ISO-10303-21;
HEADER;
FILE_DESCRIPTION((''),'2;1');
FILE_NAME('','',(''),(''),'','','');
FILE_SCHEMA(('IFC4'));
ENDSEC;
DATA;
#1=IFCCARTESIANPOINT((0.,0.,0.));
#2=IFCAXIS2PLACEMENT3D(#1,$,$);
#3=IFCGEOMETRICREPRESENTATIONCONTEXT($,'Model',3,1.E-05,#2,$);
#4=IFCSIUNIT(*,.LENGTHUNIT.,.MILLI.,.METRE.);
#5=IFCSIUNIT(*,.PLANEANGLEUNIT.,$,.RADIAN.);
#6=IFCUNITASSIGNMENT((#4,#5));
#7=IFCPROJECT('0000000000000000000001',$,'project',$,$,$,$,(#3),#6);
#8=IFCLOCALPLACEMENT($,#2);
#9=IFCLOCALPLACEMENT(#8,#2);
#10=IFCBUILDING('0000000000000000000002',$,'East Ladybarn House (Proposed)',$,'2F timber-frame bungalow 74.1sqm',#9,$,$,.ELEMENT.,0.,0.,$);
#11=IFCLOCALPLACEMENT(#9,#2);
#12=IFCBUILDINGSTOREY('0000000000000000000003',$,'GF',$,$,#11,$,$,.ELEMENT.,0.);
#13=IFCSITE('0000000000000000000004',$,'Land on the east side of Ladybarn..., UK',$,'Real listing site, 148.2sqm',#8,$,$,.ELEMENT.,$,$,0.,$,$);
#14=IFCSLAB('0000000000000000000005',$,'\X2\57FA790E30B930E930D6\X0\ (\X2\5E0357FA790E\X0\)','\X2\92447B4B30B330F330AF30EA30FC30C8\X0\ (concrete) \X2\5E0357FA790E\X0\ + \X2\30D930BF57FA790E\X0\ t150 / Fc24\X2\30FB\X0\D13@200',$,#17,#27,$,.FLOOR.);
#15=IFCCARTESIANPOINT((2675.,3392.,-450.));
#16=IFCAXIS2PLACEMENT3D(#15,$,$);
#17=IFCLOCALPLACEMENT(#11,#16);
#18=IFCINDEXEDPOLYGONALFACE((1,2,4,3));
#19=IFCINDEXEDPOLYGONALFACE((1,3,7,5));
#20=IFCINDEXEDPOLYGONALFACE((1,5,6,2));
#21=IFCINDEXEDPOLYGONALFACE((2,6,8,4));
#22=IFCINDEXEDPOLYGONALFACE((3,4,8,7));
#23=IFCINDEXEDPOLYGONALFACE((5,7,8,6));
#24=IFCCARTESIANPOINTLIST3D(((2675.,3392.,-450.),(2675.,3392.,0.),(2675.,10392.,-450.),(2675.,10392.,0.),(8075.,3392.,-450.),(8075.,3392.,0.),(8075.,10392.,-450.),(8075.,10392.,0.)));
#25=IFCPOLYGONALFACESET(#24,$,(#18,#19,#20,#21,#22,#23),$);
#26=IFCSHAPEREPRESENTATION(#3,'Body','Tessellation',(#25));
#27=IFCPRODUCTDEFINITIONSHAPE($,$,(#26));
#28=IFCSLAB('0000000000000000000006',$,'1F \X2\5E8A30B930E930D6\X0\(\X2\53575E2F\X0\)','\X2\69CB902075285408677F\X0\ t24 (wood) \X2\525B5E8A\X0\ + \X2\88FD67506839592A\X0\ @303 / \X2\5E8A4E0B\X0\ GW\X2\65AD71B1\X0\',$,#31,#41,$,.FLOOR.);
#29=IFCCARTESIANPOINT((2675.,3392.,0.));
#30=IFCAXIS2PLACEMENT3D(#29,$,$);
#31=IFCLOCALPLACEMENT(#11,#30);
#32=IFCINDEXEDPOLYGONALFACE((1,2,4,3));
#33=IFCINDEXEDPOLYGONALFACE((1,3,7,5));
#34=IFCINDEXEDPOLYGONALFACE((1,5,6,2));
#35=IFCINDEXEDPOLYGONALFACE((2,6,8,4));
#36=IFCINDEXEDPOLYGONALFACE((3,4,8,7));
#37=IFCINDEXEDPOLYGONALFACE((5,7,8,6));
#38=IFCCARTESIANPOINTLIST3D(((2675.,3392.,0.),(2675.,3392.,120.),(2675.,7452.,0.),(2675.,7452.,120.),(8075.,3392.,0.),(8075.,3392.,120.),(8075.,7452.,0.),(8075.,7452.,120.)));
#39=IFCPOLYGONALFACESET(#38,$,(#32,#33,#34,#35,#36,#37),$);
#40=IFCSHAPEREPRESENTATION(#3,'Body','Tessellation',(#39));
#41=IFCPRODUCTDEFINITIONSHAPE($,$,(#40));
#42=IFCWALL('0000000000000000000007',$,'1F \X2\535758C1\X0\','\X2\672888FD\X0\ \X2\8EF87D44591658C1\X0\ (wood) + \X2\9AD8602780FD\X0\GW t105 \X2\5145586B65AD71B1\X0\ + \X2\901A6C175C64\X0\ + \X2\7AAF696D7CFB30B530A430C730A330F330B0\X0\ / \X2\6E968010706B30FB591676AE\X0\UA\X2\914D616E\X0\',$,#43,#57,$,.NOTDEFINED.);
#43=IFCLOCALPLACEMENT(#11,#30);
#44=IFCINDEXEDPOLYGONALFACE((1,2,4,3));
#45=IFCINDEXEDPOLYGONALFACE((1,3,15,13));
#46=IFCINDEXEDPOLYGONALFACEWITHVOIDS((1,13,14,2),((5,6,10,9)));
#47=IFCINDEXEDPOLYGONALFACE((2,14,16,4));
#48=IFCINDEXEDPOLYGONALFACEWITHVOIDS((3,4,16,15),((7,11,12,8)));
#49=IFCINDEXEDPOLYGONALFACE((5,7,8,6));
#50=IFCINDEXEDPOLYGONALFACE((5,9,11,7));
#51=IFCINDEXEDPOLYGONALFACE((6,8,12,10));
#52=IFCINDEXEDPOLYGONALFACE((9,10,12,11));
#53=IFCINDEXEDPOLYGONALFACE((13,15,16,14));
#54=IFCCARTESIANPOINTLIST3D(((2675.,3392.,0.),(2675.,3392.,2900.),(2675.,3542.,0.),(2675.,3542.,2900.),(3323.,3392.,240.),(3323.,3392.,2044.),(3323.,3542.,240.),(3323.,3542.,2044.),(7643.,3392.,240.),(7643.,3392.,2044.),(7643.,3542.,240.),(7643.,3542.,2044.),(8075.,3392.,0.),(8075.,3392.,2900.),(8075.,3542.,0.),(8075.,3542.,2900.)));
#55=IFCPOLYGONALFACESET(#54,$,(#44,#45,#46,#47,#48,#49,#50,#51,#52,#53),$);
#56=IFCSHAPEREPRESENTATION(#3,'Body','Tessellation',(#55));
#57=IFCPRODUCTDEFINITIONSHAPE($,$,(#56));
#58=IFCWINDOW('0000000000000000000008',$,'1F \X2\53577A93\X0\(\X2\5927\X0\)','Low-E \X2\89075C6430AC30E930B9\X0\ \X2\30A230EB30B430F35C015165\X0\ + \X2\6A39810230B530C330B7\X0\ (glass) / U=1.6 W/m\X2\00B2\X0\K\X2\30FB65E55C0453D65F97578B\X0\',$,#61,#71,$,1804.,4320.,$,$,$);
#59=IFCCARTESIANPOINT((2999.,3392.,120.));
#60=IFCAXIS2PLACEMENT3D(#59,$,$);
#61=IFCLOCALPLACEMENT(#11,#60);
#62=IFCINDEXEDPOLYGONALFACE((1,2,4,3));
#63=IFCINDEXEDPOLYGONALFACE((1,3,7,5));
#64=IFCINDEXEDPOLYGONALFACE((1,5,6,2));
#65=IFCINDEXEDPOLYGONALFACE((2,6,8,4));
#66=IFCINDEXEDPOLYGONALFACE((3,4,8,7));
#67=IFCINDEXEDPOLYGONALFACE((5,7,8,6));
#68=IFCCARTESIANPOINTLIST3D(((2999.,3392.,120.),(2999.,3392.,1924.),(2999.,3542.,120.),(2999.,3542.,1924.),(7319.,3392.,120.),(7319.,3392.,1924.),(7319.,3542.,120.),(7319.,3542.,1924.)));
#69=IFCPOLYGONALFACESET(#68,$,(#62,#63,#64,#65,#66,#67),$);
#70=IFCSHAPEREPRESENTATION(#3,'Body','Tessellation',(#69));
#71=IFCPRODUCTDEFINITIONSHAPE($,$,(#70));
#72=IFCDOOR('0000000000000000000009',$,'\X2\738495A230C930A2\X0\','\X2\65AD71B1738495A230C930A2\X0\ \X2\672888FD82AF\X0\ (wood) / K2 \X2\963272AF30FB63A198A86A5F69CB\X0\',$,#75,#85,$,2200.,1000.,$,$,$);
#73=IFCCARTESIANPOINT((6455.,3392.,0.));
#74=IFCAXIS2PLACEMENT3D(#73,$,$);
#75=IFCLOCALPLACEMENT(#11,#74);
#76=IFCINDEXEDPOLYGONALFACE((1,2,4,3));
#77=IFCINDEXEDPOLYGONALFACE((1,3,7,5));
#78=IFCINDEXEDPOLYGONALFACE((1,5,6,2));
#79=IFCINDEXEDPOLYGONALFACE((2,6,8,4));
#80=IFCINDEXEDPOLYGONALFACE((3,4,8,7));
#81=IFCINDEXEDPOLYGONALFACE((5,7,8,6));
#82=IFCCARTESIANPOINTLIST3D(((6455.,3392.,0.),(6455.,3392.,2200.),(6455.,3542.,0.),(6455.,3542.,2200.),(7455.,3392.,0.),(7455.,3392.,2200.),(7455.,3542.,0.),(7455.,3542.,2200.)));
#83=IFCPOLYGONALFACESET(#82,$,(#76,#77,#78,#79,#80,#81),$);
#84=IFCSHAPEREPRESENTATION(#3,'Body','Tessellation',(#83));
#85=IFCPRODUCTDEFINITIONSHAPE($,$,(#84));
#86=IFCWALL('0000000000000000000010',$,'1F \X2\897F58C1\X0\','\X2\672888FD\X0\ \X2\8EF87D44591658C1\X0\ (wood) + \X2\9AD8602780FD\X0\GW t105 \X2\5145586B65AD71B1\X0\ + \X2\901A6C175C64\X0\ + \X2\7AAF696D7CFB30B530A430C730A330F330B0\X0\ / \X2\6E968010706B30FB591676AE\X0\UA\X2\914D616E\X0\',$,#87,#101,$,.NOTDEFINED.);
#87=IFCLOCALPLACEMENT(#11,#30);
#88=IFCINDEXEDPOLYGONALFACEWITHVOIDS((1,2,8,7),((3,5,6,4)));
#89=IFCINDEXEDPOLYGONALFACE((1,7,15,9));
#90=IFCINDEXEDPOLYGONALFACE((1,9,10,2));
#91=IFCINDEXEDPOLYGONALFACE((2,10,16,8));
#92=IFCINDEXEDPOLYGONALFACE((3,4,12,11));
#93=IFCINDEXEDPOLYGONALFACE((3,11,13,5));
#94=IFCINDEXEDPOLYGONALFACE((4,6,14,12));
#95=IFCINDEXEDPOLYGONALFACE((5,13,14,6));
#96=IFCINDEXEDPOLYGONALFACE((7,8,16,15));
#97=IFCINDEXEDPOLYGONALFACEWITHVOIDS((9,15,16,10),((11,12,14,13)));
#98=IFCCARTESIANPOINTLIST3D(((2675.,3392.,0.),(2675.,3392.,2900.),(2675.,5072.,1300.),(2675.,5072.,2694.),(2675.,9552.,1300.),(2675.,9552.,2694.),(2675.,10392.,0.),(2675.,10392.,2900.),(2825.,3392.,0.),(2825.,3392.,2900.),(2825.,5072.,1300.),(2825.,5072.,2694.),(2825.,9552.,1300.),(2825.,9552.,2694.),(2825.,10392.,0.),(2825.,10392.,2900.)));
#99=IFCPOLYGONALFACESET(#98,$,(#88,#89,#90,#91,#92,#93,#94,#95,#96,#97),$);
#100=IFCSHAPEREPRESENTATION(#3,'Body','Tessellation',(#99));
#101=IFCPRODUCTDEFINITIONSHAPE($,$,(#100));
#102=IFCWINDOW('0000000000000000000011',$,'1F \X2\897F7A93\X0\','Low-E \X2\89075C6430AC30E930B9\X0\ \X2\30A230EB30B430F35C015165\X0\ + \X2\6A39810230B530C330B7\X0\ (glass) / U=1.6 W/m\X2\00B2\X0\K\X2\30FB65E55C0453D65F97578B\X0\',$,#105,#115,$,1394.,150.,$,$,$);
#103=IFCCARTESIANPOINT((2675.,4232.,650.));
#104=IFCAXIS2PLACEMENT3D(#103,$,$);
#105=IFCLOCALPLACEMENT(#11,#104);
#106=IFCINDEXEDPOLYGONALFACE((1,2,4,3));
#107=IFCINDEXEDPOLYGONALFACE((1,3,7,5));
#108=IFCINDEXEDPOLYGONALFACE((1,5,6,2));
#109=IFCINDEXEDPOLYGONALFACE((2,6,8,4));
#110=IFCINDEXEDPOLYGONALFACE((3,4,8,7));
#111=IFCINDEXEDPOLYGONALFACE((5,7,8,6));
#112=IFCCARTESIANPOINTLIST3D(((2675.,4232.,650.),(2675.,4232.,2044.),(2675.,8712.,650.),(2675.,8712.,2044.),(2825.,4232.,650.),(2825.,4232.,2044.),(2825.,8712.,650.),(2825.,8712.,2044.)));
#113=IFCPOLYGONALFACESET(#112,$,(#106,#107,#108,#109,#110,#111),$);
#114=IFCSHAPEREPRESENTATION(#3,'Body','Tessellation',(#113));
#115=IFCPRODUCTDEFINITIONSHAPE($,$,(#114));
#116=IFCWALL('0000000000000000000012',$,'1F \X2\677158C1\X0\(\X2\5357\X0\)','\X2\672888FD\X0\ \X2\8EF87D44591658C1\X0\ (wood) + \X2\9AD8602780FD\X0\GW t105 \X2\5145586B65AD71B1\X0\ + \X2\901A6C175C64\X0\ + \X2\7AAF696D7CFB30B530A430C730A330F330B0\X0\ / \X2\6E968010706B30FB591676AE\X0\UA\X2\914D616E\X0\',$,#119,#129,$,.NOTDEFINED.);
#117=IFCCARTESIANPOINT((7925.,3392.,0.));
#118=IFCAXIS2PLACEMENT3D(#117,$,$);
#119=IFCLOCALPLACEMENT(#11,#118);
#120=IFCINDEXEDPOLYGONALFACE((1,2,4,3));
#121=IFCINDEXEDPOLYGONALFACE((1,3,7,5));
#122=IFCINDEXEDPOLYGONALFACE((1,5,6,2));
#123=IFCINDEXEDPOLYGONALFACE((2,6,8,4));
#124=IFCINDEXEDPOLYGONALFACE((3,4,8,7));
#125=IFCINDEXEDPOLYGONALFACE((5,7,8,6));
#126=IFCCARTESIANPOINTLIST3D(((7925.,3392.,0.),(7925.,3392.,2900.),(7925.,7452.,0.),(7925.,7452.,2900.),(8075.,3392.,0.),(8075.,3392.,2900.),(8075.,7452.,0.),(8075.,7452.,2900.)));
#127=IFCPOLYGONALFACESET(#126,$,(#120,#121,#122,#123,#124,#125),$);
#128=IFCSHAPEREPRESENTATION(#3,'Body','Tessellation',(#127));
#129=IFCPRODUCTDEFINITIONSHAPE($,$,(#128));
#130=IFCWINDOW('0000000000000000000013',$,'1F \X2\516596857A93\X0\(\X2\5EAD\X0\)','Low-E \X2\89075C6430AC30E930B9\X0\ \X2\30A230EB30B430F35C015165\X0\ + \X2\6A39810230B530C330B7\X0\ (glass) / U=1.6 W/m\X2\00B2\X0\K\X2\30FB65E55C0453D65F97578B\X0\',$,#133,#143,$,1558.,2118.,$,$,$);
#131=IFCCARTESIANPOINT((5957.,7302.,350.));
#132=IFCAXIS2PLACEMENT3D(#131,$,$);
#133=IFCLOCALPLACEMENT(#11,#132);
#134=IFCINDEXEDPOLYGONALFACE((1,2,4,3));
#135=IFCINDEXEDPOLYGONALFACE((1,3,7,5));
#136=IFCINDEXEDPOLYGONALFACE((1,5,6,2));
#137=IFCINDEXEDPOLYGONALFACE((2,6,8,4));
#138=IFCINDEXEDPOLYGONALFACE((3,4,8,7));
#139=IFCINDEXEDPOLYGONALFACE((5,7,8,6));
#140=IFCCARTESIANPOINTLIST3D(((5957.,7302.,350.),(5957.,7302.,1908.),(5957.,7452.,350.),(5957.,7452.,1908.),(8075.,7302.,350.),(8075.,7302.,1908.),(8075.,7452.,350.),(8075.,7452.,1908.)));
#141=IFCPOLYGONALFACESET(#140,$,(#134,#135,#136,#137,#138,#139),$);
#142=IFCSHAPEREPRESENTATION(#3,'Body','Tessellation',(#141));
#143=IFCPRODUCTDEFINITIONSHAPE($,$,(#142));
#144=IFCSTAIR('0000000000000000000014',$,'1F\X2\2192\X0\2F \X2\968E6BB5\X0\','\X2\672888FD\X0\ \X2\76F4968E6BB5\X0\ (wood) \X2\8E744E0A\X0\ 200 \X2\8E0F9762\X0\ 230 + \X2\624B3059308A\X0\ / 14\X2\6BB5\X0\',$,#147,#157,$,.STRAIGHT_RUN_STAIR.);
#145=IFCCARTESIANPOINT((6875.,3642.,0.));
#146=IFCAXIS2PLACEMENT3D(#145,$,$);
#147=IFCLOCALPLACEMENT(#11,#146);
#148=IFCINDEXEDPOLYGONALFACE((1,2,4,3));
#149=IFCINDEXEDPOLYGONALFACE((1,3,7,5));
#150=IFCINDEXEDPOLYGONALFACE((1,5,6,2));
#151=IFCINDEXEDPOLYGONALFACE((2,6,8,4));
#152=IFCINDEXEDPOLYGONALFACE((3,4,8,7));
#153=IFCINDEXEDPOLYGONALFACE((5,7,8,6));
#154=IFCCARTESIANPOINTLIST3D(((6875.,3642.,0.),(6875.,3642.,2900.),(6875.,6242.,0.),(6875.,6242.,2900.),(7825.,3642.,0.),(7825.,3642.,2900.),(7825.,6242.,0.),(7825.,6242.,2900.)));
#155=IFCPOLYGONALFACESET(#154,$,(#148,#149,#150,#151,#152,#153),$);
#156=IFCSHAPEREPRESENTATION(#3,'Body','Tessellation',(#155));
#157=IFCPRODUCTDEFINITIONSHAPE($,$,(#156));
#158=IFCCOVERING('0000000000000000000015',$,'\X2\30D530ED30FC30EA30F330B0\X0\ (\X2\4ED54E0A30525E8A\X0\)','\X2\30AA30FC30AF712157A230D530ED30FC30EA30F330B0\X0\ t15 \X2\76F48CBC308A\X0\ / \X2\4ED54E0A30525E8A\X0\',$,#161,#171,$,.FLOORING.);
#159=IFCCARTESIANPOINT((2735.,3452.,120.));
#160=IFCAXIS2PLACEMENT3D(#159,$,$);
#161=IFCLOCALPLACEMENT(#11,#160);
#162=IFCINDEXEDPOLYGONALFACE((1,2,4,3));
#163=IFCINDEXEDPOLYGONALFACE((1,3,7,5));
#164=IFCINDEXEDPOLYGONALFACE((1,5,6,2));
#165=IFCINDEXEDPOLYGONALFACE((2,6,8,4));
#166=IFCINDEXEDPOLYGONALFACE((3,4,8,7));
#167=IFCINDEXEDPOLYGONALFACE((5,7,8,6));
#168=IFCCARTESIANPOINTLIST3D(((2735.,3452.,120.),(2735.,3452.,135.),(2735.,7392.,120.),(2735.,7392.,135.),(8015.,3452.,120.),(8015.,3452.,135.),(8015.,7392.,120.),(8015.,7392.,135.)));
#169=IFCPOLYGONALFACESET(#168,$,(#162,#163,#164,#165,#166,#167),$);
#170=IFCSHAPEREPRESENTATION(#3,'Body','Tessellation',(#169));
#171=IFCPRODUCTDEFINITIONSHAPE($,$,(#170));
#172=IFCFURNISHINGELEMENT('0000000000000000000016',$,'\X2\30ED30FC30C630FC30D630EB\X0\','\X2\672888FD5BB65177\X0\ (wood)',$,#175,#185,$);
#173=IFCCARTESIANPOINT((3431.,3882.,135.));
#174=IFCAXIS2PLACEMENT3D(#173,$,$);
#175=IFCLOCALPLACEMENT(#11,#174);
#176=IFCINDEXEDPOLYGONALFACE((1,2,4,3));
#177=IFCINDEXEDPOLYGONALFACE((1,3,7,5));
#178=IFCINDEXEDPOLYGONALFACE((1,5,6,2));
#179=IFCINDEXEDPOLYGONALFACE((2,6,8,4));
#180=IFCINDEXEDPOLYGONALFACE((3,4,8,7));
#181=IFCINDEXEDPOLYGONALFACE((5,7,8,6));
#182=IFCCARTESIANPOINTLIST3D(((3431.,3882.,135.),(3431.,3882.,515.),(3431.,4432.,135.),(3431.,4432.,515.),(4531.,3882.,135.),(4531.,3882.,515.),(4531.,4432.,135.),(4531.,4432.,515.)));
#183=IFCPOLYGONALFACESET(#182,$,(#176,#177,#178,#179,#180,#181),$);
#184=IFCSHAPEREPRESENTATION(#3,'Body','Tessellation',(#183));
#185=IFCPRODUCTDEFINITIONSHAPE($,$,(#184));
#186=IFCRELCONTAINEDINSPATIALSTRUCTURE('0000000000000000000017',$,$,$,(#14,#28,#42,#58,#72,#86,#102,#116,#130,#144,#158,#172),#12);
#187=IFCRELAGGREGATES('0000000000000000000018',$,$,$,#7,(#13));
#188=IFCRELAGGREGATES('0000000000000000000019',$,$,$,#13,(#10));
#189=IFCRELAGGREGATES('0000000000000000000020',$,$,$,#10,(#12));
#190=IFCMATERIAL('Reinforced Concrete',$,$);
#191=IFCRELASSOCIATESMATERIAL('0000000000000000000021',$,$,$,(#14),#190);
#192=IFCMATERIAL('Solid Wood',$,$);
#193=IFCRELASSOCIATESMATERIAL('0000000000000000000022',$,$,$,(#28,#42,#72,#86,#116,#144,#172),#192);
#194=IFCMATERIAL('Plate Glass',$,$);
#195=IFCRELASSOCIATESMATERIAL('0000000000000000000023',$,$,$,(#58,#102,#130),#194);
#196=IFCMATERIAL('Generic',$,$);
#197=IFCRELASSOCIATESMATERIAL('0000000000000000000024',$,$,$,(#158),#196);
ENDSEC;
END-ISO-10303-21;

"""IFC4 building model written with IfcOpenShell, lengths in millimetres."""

from ifc_helpers import new_model, si_unit, frame, frame_2d, origin, place, context, project, spatial, rectangle, extrude, material, element, fill, save


model = new_model("IFC4")

# Units and contexts
model_context = context("Model", 3, precision=1e-05, world=origin())
ifc_project = project(units=[si_unit("LENGTHUNIT", "METRE", prefix="MILLI"), si_unit("PLANEANGLEUNIT", "RADIAN")], contexts=[model_context])

# Site, building, storey
site_placement = place(None, origin())
site = spatial("IfcSite", under=ifc_project, at=site_placement, Name="Land on the east side of Ladybarn..., UK", ObjectType="Real listing site, 148.2sqm", CompositionType="ELEMENT", RefElevation=0.0)
building_placement = place(site_placement, origin())
building = spatial("IfcBuilding", under=site, at=building_placement, Name="East Ladybarn House (Proposed)", ObjectType="2F timber-frame bungalow 74.1sqm", CompositionType="ELEMENT", ElevationOfRefHeight=0.0, ElevationOfTerrain=0.0)
storey_placement = place(building_placement, origin())
storey = spatial("IfcBuildingStorey", under=building, at=storey_placement, Name="GF", CompositionType="ELEMENT", Elevation=0.0)

# Slabs
ifc_material_1 = material(Name="Reinforced Concrete")
slab_1_placement = place(storey_placement, frame((2675.0, 3392.0, -450.0)))
element("IfcSlab", 1, at=slab_1_placement, inside=storey, material=ifc_material_1, Name="基礎スラブ (布基礎)", Description="鉄筋コンクリート (concrete) 布基礎 + ベタ基礎 t150 / Fc24・D13@200", PredefinedType="FLOOR", context=model_context, shape_type="SweptSolid", body=[
    extrude(rectangle(XDim=5400.0, YDim=7000.0, at=frame_2d((2700.0, 3500.0))), frame((2675.0, 3392.0, -450.0)), (0.0, 0.0, 1.0), 450.0),
])
ifc_material_2 = material(Name="Solid Wood")
slab_2_placement = place(storey_placement, frame((2675.0, 3392.0, 0.0)))
element("IfcSlab", 2, at=slab_2_placement, inside=storey, material=ifc_material_2, Name="1F 床スラブ(南帯)", Description="構造用合板 t24 (wood) 剛床 + 製材根太 @303 / 床下 GW断熱", PredefinedType="FLOOR", context=model_context, shape_type="SweptSolid", body=[
    extrude(rectangle(XDim=5400.0, YDim=4060.0, at=frame_2d((2700.0, 2030.0))), frame((2675.0, 3392.0, 0.0)), (0.0, 0.0, 1.0), 120.0),
])

# Wall, openings, window, door
wall_1_placement = place(storey_placement, frame((2675.0, 3392.0, 0.0)))
wall_1 = element("IfcWall", 3, at=wall_1_placement, inside=storey, material=ifc_material_2, Name="1F 南壁", Description="木製 軸組外壁 (wood) + 高性能GW t105 充填断熱 + 通気層 + 窯業系サイディング / 準耐火・外皮UA配慮", PredefinedType="NOTDEFINED", context=model_context, shape_type="SweptSolid", body=[
    extrude(rectangle(XDim=5400.0, YDim=150.0, at=frame_2d((2700.0, 75.0))), frame((2675.0, 3392.0, 0.0)), (0.0, 0.0, 1.0), 2900.0),
])
opening_1_placement = place(storey_placement, frame((2999.0, 3392.0, 120.0)))
opening_1 = element("IfcOpeningElement", 4, at=opening_1_placement, cuts=wall_1, PredefinedType="NOTDEFINED", context=model_context, shape_type="SweptSolid", body=[
    extrude(rectangle(XDim=4320.0, YDim=150.0, at=frame_2d((2160.0, 75.0))), frame((2999.0, 3392.0, 120.0)), (0.0, 0.0, 1.0), 1804.0),
])
opening_2_placement = place(storey_placement, frame((6455.0, 3392.0, 0.0)))
opening_2 = element("IfcOpeningElement", 5, at=opening_2_placement, cuts=wall_1, PredefinedType="NOTDEFINED", context=model_context, shape_type="SweptSolid", body=[
    extrude(rectangle(XDim=1000.0, YDim=150.0, at=frame_2d((500.0, 75.0))), frame((6455.0, 3392.0, 0.0)), (0.0, 0.0, 1.0), 2200.0),
])
ifc_material_3 = material(Name="Plate Glass")
window_1_placement = place(storey_placement, frame((2999.0, 3392.0, 120.0)))
window_1 = element("IfcWindow", 6, at=window_1_placement, inside=storey, material=ifc_material_3, Name="1F 南窓(大)", Description="Low-E 複層ガラス アルゴン封入 + 樹脂サッシ (glass) / U=1.6 W/m²K・日射取得型", OverallHeight=1804.0, OverallWidth=4320.0, context=model_context, shape_type="SweptSolid", body=[
    extrude(rectangle(XDim=4320.0, YDim=150.0, at=frame_2d((2160.0, 75.0))), frame((2999.0, 3392.0, 120.0)), (0.0, 0.0, 1.0), 1804.0),
])
fill(opening_1, window_1)
door_1_placement = place(storey_placement, frame((6455.0, 3392.0, 0.0)))
door_1 = element("IfcDoor", 7, at=door_1_placement, inside=storey, material=ifc_material_2, Name="玄関ドア", Description="断熱玄関ドア 木製芯 (wood) / K2 防犯・採風機構", OverallHeight=2200.0, OverallWidth=1000.0, context=model_context, shape_type="SweptSolid", body=[
    extrude(rectangle(XDim=1000.0, YDim=150.0, at=frame_2d((500.0, 75.0))), frame((6455.0, 3392.0, 0.0)), (0.0, 0.0, 1.0), 2200.0),
])
fill(opening_2, door_1)

# Walls, openings, windows
wall_2_placement = place(storey_placement, frame((2675.0, 3392.0, 0.0)))
wall_2 = element("IfcWall", 8, at=wall_2_placement, inside=storey, material=ifc_material_2, Name="1F 西壁", Description="木製 軸組外壁 (wood) + 高性能GW t105 充填断熱 + 通気層 + 窯業系サイディング / 準耐火・外皮UA配慮", PredefinedType="NOTDEFINED", context=model_context, shape_type="SweptSolid", body=[
    extrude(rectangle(XDim=150.0, YDim=7000.0, at=frame_2d((75.0, 3500.0))), frame((2675.0, 3392.0, 0.0)), (0.0, 0.0, 1.0), 2900.0),
])
opening_3_placement = place(storey_placement, frame((2675.0, 4232.0, 650.0)))
opening_3 = element("IfcOpeningElement", 9, at=opening_3_placement, cuts=wall_2, PredefinedType="NOTDEFINED", context=model_context, shape_type="SweptSolid", body=[
    extrude(rectangle(XDim=150.0, YDim=4480.0, at=frame_2d((75.0, 2240.0))), frame((2675.0, 4232.0, 650.0)), (0.0, 0.0, 1.0), 1394.0),
])
window_2_placement = place(storey_placement, frame((2675.0, 4232.0, 650.0)))
window_2 = element("IfcWindow", 10, at=window_2_placement, inside=storey, material=ifc_material_3, Name="1F 西窓", Description="Low-E 複層ガラス アルゴン封入 + 樹脂サッシ (glass) / U=1.6 W/m²K・日射取得型", OverallHeight=1394.0, OverallWidth=150.0, context=model_context, shape_type="SweptSolid", body=[
    extrude(rectangle(XDim=150.0, YDim=4480.0, at=frame_2d((75.0, 2240.0))), frame((2675.0, 4232.0, 650.0)), (0.0, 0.0, 1.0), 1394.0),
])
fill(opening_3, window_2)
wall_3_placement = place(storey_placement, frame((7925.0, 3392.0, 0.0)))
wall_3 = element("IfcWall", 11, at=wall_3_placement, inside=storey, material=ifc_material_2, Name="1F 東壁(南)", Description="木製 軸組外壁 (wood) + 高性能GW t105 充填断熱 + 通気層 + 窯業系サイディング / 準耐火・外皮UA配慮", PredefinedType="NOTDEFINED", context=model_context, shape_type="SweptSolid", body=[
    extrude(rectangle(XDim=150.0, YDim=4060.0, at=frame_2d((75.0, 2030.0))), frame((7925.0, 3392.0, 0.0)), (0.0, 0.0, 1.0), 2900.0),
])
opening_4_placement = place(storey_placement, frame((5957.0, 7302.0, 350.0)))
opening_4 = element("IfcOpeningElement", 12, at=opening_4_placement, cuts=wall_3, PredefinedType="NOTDEFINED", context=model_context, shape_type="SweptSolid", body=[
    extrude(rectangle(XDim=2118.0, YDim=150.0, at=frame_2d((1059.0, 75.0))), frame((5957.0, 7302.0, 350.0)), (0.0, 0.0, 1.0), 1558.0),
])
window_3_placement = place(storey_placement, frame((5957.0, 7302.0, 350.0)))
window_3 = element("IfcWindow", 13, at=window_3_placement, inside=storey, material=ifc_material_3, Name="1F 入隅窓(庭)", Description="Low-E 複層ガラス アルゴン封入 + 樹脂サッシ (glass) / U=1.6 W/m²K・日射取得型", OverallHeight=1558.0, OverallWidth=2118.0, context=model_context, shape_type="SweptSolid", body=[
    extrude(rectangle(XDim=2118.0, YDim=150.0, at=frame_2d((1059.0, 75.0))), frame((5957.0, 7302.0, 350.0)), (0.0, 0.0, 1.0), 1558.0),
])
fill(opening_4, window_3)

# Stair
stair_placement = place(storey_placement, frame((6875.0, 3642.0, 0.0)))
element("IfcStair", 14, at=stair_placement, inside=storey, material=ifc_material_2, Name="1F→2F 階段", Description="木製 直階段 (wood) 蹴上 200 踏面 230 + 手すり / 14段", PredefinedType="STRAIGHT_RUN_STAIR", context=model_context, shape_type="SweptSolid", body=[
    extrude(rectangle(XDim=950.0, YDim=2600.0, at=frame_2d((475.0, 1300.0))), frame((6875.0, 3642.0, 0.0)), (0.0, 0.0, 1.0), 2900.0),
])

# Covering
ifc_material_4 = material(Name="Generic")
covering_placement = place(storey_placement, frame((2735.0, 3452.0, 120.0)))
element("IfcCovering", 15, at=covering_placement, inside=storey, material=ifc_material_4, Name="フローリング (仕上げ床)", Description="オーク無垢フローリング t15 直貼り / 仕上げ床", PredefinedType="FLOORING", context=model_context, shape_type="SweptSolid", body=[
    extrude(rectangle(XDim=5280.0, YDim=3940.0, at=frame_2d((2640.0, 1970.0))), frame((2735.0, 3452.0, 120.0)), (0.0, 0.0, 1.0), 15.0),
])

# Furnishing element
furnishing_1_placement = place(storey_placement, frame((3431.0, 3882.0, 135.0)))
element("IfcFurnishingElement", 16, at=furnishing_1_placement, inside=storey, material=ifc_material_2, Name="ローテーブル", Description="木製家具 (wood)", context=model_context, shape_type="SweptSolid", body=[
    extrude(rectangle(XDim=1100.0, YDim=550.0, at=frame_2d((550.0, 275.0))), frame((3431.0, 3882.0, 135.0)), (0.0, 0.0, 1.0), 380.0),
])

save(model, "model.ifc")
